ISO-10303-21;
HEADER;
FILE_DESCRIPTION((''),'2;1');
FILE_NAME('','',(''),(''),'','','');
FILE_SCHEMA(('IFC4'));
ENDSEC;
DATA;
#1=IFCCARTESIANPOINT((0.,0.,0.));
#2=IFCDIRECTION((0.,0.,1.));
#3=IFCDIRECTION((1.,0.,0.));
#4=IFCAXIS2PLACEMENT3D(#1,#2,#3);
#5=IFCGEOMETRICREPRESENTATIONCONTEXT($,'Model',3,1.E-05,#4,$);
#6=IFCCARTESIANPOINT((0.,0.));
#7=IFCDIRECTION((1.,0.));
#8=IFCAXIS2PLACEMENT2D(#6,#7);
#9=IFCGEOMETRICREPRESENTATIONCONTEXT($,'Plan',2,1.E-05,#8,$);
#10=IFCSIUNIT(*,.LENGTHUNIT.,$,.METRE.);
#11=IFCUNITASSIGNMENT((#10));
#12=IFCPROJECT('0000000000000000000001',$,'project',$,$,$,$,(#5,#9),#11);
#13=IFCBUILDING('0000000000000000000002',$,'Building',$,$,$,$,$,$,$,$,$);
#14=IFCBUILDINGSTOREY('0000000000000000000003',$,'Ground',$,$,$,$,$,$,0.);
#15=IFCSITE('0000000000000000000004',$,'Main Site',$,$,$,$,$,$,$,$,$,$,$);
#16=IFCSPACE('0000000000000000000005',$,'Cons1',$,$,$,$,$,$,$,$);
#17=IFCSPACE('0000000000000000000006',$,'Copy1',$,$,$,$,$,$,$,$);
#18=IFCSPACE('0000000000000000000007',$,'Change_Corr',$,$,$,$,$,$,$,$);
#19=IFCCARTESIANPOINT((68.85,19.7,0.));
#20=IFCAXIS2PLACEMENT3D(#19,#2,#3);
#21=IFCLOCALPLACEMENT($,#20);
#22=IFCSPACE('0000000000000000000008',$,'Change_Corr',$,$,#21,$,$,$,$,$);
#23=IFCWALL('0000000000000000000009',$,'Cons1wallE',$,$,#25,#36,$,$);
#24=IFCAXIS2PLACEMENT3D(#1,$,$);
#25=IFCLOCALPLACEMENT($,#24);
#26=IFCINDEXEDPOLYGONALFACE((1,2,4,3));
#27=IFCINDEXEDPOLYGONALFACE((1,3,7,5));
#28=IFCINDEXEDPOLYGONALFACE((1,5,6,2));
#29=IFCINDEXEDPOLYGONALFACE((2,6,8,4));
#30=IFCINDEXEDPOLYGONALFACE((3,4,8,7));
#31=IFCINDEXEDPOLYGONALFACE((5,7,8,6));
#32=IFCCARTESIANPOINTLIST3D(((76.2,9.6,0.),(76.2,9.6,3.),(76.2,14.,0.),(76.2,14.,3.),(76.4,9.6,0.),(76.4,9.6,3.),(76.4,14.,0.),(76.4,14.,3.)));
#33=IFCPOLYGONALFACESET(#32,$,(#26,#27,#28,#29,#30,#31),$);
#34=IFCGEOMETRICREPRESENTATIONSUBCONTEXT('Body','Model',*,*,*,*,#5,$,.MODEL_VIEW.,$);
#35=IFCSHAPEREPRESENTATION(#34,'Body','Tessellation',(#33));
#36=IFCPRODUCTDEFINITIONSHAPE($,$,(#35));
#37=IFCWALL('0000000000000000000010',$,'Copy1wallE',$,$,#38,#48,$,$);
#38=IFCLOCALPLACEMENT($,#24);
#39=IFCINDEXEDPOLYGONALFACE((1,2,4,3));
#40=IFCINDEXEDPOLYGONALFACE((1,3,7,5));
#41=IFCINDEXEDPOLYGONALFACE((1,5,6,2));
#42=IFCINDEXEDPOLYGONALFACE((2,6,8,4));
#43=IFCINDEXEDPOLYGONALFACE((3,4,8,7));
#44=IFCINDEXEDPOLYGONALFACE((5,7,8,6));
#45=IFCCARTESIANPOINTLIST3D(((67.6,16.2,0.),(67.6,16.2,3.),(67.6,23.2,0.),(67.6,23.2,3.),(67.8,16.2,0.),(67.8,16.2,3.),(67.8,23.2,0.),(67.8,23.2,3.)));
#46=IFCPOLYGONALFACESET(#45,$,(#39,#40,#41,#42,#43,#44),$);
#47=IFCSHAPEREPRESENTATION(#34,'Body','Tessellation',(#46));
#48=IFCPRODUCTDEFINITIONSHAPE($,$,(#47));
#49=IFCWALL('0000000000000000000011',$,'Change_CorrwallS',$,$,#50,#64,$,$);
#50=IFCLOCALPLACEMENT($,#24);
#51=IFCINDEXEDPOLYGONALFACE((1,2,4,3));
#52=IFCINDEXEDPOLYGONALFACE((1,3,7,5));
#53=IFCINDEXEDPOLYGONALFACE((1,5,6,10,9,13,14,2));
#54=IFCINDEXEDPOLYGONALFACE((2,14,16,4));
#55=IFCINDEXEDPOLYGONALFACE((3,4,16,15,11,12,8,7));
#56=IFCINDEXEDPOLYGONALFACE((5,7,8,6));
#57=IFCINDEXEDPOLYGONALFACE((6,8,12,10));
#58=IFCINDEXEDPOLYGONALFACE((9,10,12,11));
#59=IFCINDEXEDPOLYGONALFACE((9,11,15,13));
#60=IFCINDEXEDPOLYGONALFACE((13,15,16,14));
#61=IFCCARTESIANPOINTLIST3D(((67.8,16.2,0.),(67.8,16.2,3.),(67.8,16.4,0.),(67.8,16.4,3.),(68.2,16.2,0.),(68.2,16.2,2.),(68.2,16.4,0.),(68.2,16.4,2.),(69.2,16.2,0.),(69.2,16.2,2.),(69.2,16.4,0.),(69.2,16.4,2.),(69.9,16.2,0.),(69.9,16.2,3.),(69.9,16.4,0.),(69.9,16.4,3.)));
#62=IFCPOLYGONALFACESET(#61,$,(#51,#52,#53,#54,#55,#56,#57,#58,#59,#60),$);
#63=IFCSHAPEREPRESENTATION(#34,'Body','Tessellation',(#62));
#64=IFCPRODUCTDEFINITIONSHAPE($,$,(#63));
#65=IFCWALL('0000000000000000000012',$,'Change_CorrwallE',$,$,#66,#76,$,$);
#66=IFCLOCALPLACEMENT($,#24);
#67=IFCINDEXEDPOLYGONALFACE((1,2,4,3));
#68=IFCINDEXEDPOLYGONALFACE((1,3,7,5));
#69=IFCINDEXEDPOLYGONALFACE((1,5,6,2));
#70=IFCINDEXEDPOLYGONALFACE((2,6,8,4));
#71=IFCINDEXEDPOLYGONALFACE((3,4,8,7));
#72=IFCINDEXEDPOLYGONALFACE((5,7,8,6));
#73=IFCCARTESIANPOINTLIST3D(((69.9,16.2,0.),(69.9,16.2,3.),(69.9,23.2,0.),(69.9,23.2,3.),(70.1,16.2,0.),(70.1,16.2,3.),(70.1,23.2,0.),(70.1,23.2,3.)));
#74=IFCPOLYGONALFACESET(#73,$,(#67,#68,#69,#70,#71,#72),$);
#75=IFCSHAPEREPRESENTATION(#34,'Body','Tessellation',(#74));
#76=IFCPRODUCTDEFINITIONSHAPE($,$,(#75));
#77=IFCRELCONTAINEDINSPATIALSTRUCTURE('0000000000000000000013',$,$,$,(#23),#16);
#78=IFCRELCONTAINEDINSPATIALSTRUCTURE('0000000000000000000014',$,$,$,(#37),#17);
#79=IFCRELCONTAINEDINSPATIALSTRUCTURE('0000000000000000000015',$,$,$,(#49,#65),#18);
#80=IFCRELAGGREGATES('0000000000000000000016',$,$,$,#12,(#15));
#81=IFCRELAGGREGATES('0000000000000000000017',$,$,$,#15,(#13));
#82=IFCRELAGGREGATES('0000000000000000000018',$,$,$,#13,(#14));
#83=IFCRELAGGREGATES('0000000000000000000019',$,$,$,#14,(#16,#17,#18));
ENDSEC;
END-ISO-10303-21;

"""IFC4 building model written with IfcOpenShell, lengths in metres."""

from ifc_helpers import new_model, si_unit, frame, origin_with_axes, origin_2d_with_axis, place, context, subcontext, project, spatial, indexed_curve, outline, extrude, element, save


model = new_model("IFC4")

# Units and contexts
model_context = context("Model", 3, precision=1e-05, world=origin_with_axes())
plan_context = context("Plan", 2, precision=1e-05, world=origin_2d_with_axis())
body_context = subcontext(model_context, "Body", "Model", "MODEL_VIEW")
ifc_project = project(units=[si_unit("LENGTHUNIT", "METRE")], contexts=[model_context, plan_context])

# Site, building, storey
site = spatial("IfcSite", under=ifc_project, Name="Main Site")
building = spatial("IfcBuilding", under=site, Name="Building")
storey = spatial("IfcBuildingStorey", under=building, Name="Ground", Elevation=0.0)

# Shared definitions
space_1 = spatial("IfcSpace", under=storey, Name="Cons1")

# Wall
for number, where, z_axis, x_axis, name in (
    (1, (76.4, 9.6, 0.0), (0.0, 0.0, 1.0), (0.0, 1.0, 0.0), "Cons1wallE"),
):
    element("IfcWall", number, at=place(None, frame(where, z_axis=z_axis, x_axis=x_axis)), inside=space_1, Name=name, context=body_context, shape_type="SweptSolid", body=[
        extrude(outline(indexed_curve([(0.0, 0.0), (0.0, 0.2), (4.4, 0.2), (4.4, 0.0), (0.0, 0.0)], self_intersect=False)), origin_with_axes(), (0.0, 0.0, 1.0), 3.0),
    ])

# Shared definitions
space_2 = spatial("IfcSpace", under=storey, Name="Copy1")

# Wall
wall_1_placement = place(None, frame((67.8, 16.2, 0.0), z_axis=(0.0, 0.0, 1.0), x_axis=(0.0, 1.0, 0.0)))
element("IfcWall", 2, at=wall_1_placement, inside=space_2, Name="Copy1wallE", context=body_context, shape_type="SweptSolid", body=[
    extrude(outline(indexed_curve([(0.0, 0.0), (0.0, 0.2), (7.0, 0.2), (7.0, 0.0), (0.0, 0.0)], self_intersect=False)), origin_with_axes(), (0.0, 0.0, 1.0), 3.0),
])

# Shared definitions
space_3 = spatial("IfcSpace", under=storey, Name="Change_Corr")

# Wall
wall_2_placement = place(None, frame((67.8, 16.2, 0.0), z_axis=(0.0, 0.0, 1.0), x_axis=(1.0, 0.0, 0.0)))
wall_2 = element("IfcWall", 3, at=wall_2_placement, inside=space_3, Name="Change_CorrwallS", context=body_context, shape_type="SweptSolid", body=[
    extrude(outline(indexed_curve([(0.0, 0.0), (0.0, 0.2), (2.1, 0.2), (2.1, 0.0), (0.0, 0.0)], self_intersect=False)), origin_with_axes(), (0.0, 0.0, 1.0), 3.0),
])

# Shared definitions
space_4_placement = place(None, frame((68.85, 19.7, 0.0), z_axis=(0.0, 0.0, 1.0), x_axis=(1.0, 0.0, 0.0)))
space_4 = spatial("IfcSpace", at=space_4_placement, Name="Change_Corr")

# Opening
opening_1_placement = place(wall_2_placement, frame((0.4, 0.0, 0.0), z_axis=(0.0, 0.0, 1.0), x_axis=(1.0, 0.0, 0.0)))
element("IfcOpeningElement", 4, at=opening_1_placement, inside=space_4, cuts=wall_2, context=body_context, shape_type="SweptSolid", body=[
    extrude(outline(indexed_curve([(0.0, 0.0), (0.0, 0.4), (1.0, 0.4), (1.0, 0.0), (0.0, 0.0)], self_intersect=False)), origin_with_axes(), (0.0, 0.0, 1.0), 2.0),
])

# Wall
for number, where, z_axis, x_axis, name in (
    (5, (70.1, 16.2, 0.0), (0.0, 0.0, 1.0), (0.0, 1.0, 0.0), "Change_CorrwallE"),
):
    element("IfcWall", number, at=place(None, frame(where, z_axis=z_axis, x_axis=x_axis)), inside=space_3, Name=name, context=body_context, shape_type="SweptSolid", body=[
        extrude(outline(indexed_curve([(0.0, 0.0), (0.0, 0.2), (7.0, 0.2), (7.0, 0.0), (0.0, 0.0)], self_intersect=False)), origin_with_axes(), (0.0, 0.0, 1.0), 3.0),
    ])

save(model, "model.ifc")
